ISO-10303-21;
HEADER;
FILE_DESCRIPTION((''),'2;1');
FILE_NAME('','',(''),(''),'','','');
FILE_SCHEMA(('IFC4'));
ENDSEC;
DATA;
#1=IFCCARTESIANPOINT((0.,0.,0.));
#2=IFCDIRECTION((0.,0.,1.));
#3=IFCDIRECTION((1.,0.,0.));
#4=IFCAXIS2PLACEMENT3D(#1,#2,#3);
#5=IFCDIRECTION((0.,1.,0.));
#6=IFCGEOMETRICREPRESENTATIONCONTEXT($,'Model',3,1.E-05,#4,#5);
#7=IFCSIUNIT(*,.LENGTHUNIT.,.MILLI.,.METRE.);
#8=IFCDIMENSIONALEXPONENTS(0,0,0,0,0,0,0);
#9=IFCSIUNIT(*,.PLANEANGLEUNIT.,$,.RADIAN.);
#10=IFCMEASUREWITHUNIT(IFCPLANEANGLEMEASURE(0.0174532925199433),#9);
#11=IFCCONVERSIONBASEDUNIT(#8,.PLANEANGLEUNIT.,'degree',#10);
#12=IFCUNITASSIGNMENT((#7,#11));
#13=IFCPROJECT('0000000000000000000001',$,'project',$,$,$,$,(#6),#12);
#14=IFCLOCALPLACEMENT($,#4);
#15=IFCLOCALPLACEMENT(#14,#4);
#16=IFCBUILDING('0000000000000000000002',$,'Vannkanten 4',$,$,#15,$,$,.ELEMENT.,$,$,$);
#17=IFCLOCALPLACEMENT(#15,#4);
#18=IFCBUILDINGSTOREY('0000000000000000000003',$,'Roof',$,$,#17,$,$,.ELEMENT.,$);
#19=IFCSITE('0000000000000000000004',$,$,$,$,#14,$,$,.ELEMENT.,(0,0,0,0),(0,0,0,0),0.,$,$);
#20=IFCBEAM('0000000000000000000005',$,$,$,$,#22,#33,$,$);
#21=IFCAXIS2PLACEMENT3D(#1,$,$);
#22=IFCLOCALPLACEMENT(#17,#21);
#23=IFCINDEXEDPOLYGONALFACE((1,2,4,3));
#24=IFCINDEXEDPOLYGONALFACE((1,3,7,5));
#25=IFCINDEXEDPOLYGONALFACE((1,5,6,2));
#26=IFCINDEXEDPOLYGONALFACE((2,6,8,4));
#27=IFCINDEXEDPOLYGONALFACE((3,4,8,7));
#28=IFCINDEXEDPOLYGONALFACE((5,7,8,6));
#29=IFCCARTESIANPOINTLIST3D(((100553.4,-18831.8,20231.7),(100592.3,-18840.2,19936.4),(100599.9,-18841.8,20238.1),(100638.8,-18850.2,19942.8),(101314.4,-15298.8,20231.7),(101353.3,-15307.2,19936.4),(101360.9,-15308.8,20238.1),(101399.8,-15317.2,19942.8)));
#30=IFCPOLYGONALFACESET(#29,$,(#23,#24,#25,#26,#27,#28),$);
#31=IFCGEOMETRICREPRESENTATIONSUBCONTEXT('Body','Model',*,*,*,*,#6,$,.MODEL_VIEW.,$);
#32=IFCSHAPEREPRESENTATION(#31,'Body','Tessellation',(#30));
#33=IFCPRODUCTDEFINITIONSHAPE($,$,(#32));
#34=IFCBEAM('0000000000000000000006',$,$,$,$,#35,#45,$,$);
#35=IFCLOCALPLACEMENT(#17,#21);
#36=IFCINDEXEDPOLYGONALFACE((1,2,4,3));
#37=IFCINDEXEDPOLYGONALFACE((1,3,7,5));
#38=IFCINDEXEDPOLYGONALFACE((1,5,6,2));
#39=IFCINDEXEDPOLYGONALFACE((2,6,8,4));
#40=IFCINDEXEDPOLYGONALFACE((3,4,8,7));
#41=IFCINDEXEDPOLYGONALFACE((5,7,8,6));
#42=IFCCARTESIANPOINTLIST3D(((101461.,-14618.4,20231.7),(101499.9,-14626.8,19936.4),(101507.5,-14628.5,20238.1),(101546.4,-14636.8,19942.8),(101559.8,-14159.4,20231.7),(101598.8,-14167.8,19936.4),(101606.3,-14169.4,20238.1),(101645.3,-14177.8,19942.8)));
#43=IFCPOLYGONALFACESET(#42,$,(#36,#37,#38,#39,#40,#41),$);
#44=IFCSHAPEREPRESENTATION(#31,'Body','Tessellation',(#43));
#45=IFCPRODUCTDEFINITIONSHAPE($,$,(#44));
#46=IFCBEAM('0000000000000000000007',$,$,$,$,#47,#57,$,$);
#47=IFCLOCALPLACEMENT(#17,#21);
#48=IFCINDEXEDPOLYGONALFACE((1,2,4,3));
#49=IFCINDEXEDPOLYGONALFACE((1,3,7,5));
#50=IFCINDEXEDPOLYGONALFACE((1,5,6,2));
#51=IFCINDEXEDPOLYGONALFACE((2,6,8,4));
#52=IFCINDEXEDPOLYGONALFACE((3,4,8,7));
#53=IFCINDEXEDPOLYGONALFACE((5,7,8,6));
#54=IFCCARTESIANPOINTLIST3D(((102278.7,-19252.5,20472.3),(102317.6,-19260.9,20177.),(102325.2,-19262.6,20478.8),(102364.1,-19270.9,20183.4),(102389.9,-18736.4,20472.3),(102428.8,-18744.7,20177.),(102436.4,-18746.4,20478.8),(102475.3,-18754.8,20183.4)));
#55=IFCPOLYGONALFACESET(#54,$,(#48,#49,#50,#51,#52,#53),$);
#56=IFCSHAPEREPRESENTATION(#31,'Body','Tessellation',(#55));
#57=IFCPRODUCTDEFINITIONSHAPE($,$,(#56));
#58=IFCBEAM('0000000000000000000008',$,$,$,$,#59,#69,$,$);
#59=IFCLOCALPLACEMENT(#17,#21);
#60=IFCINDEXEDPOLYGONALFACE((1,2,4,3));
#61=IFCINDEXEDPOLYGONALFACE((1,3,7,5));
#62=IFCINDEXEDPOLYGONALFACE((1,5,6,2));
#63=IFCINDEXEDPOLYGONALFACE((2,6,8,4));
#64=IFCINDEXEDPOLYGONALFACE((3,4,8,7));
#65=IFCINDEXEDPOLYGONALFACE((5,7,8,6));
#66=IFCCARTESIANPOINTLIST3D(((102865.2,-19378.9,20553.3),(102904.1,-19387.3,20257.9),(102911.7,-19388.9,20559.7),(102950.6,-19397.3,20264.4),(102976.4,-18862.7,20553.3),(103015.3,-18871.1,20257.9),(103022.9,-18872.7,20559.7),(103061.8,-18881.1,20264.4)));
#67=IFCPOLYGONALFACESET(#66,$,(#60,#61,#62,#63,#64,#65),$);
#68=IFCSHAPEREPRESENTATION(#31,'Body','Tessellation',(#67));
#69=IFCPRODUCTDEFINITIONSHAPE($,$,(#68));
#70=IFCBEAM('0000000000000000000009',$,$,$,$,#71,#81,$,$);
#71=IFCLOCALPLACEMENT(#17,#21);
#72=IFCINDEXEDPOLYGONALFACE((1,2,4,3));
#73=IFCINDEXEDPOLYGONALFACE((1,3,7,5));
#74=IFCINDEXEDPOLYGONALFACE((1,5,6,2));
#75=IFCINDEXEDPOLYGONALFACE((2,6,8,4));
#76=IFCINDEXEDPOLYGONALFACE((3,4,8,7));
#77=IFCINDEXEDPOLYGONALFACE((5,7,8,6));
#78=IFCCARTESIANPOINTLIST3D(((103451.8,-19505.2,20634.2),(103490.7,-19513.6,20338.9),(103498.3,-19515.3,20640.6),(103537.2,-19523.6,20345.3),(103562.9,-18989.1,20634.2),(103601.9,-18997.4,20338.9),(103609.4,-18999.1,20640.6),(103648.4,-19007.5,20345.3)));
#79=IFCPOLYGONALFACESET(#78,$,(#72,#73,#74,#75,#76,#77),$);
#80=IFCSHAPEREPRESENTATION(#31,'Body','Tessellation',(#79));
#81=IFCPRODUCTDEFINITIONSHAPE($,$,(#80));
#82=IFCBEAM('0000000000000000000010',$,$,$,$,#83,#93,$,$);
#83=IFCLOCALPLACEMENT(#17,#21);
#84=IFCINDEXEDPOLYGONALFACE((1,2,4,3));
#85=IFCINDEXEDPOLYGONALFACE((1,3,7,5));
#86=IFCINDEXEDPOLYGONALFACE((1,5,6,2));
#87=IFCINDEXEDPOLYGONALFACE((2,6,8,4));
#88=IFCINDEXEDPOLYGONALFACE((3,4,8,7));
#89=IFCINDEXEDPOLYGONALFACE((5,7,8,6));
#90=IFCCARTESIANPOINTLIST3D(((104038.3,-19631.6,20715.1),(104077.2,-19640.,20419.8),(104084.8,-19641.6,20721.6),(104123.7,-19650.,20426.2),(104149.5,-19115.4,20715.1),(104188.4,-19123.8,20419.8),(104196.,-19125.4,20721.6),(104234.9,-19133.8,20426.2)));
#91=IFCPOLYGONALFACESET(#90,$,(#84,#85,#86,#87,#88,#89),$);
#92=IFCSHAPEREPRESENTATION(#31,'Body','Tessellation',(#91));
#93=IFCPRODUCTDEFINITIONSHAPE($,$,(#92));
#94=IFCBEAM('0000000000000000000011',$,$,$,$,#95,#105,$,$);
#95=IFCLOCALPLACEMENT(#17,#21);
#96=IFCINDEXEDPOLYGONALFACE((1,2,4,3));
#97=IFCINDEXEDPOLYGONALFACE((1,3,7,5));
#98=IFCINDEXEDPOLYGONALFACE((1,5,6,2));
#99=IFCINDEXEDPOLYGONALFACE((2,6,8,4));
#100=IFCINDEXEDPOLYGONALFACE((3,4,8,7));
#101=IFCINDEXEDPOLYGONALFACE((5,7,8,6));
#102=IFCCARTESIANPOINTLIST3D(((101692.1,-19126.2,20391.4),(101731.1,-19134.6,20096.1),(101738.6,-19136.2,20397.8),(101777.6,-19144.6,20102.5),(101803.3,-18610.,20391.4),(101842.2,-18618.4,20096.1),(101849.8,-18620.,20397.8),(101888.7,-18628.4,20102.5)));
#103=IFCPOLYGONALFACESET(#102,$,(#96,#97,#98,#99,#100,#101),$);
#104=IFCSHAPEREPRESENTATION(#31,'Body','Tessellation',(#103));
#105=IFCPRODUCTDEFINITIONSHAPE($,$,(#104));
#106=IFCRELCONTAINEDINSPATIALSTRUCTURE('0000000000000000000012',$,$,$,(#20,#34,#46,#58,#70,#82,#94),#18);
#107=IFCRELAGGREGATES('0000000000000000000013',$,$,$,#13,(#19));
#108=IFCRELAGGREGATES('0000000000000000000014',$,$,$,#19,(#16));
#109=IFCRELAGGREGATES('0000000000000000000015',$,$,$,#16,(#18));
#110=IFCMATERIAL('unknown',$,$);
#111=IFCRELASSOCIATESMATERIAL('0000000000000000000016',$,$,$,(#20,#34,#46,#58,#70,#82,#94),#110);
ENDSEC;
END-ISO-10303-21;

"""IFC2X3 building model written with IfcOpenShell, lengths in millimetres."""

from ifc_helpers import new_model, entity, si_unit, converted_unit, direction, frame, origin_with_axes, place, context, subcontext, project, spatial, polyline, segment, composite_curve, outline, extrude, material, element, save


model = new_model("IFC2X3")

# Units and contexts
model_context = context("Model", 3, precision=1e-05, world=origin_with_axes(), true_north=direction((0.0, 1.0, 0.0)))
body_context = subcontext(model_context, "Body", "Model", "MODEL_VIEW")
ifc_project = project(units=[si_unit("LENGTHUNIT", "METRE", prefix="MILLI"), converted_unit("PLANEANGLEUNIT", "degree", entity("IfcPlaneAngleMeasure", 0.0174532925199433), si_unit("PLANEANGLEUNIT", "RADIAN"), dimensions=[0, 0, 0, 0, 0, 0, 0])], contexts=[model_context])

# Site, building, storey
site_placement = place(None, origin_with_axes())
site = spatial("IfcSite", under=ifc_project, at=site_placement, CompositionType="ELEMENT", RefLatitude=(0, 0, 0, 0), RefLongitude=(0, 0, 0, 0), RefElevation=0.0)
building_placement = place(site_placement, origin_with_axes())
building = spatial("IfcBuilding", under=site, at=building_placement, Name="Vannkanten 4", CompositionType="ELEMENT")
storey_placement = place(building_placement, origin_with_axes())
storey = spatial("IfcBuildingStorey", under=building, at=storey_placement, Name="Roof", CompositionType="ELEMENT")

# Shared definitions
ifc_material = material(Name="unknown")

# Beams
beam_1_placement = place(storey_placement, frame((100596.1, -18841.0, 20087.3), z_axis=(0.210582, 0.977576, 0.0), x_axis=(-0.968803, 0.208692, -0.133675)))
element("IfcBeam", 1, at=beam_1_placement, inside=storey, material=ifc_material, context=body_context, shape_type="SweptSolid", body=[
    extrude(outline(composite_curve([segment(polyline([(-24.0, -149.0), (-24.0, 149.0), (24.0, 149.0), (24.0, -149.0), (-24.0, -149.0)]), True, "CONTINUOUS")], self_intersect=False)), frame((0.0, 0.0, 0.0), z_axis=(0.0, 0.0, 1.0), x_axis=(1.0, 0.0, 0.0)), (0.0, 0.0, 1.0), 3614.0),
])
beam_2_placement = place(storey_placement, frame((101503.7, -14627.6, 20087.3), z_axis=(0.210582, 0.977576, 0.0), x_axis=(-0.968803, 0.208692, -0.133675)))
element("IfcBeam", 2, at=beam_2_placement, inside=storey, material=ifc_material, context=body_context, shape_type="SweptSolid", body=[
    extrude(outline(composite_curve([segment(polyline([(-24.0, -149.0), (-24.0, 149.0), (24.0, 149.0), (24.0, -149.0), (-24.0, -149.0)]), True, "CONTINUOUS")], self_intersect=False)), frame((0.0, 0.0, 0.0), z_axis=(0.0, 0.0, 1.0), x_axis=(1.0, 0.0, 0.0)), (0.0, 0.0, 1.0), 469.5),
])
beam_3_placement = place(storey_placement, frame((102321.4, -19261.7, 20327.9), z_axis=(0.210582, 0.977576, 0.0), x_axis=(-0.968803, 0.208692, -0.133675)))
element("IfcBeam", 3, at=beam_3_placement, inside=storey, material=ifc_material, context=body_context, shape_type="SweptSolid", body=[
    extrude(outline(composite_curve([segment(polyline([(-24.0, -149.0), (-24.0, 149.0), (24.0, 149.0), (24.0, -149.0), (-24.0, -149.0)]), True, "CONTINUOUS")], self_intersect=False)), frame((0.0, 0.0, 0.0), z_axis=(0.0, 0.0, 1.0), x_axis=(1.0, 0.0, 0.0)), (0.0, 0.0, 1.0), 528.0),
])
beam_4_placement = place(storey_placement, frame((102907.9, -19388.1, 20408.8), z_axis=(0.210582, 0.977576, 0.0), x_axis=(-0.968803, 0.208692, -0.133675)))
element("IfcBeam", 4, at=beam_4_placement, inside=storey, material=ifc_material, context=body_context, shape_type="SweptSolid", body=[
    extrude(outline(composite_curve([segment(polyline([(-24.0, -149.0), (-24.0, 149.0), (24.0, 149.0), (24.0, -149.0), (-24.0, -149.0)]), True, "CONTINUOUS")], self_intersect=False)), frame((0.0, 0.0, 0.0), z_axis=(0.0, 0.0, 1.0), x_axis=(1.0, 0.0, 0.0)), (0.0, 0.0, 1.0), 528.0),
])
beam_5_placement = place(storey_placement, frame((103494.5, -19514.4, 20489.7), z_axis=(0.210582, 0.977576, 0.0), x_axis=(-0.968803, 0.208692, -0.133675)))
element("IfcBeam", 5, at=beam_5_placement, inside=storey, material=ifc_material, context=body_context, shape_type="SweptSolid", body=[
    extrude(outline(composite_curve([segment(polyline([(-24.0, -149.0), (-24.0, 149.0), (24.0, 149.0), (24.0, -149.0), (-24.0, -149.0)]), True, "CONTINUOUS")], self_intersect=False)), frame((0.0, 0.0, 0.0), z_axis=(0.0, 0.0, 1.0), x_axis=(1.0, 0.0, 0.0)), (0.0, 0.0, 1.0), 528.0),
])
beam_6_placement = place(storey_placement, frame((104081.0, -19640.8, 20570.7), z_axis=(0.210582, 0.977576, 0.0), x_axis=(-0.968803, 0.208692, -0.133675)))
element("IfcBeam", 6, at=beam_6_placement, inside=storey, material=ifc_material, context=body_context, shape_type="SweptSolid", body=[
    extrude(outline(composite_curve([segment(polyline([(-24.0, -149.0), (-24.0, 149.0), (24.0, 149.0), (24.0, -149.0), (-24.0, -149.0)]), True, "CONTINUOUS")], self_intersect=False)), frame((0.0, 0.0, 0.0), z_axis=(0.0, 0.0, 1.0), x_axis=(1.0, 0.0, 0.0)), (0.0, 0.0, 1.0), 528.0),
])
beam_7_placement = place(storey_placement, frame((101734.8, -19135.4, 20247.0), z_axis=(0.210582, 0.977576, 0.0), x_axis=(-0.968803, 0.208692, -0.133675)))
element("IfcBeam", 7, at=beam_7_placement, inside=storey, material=ifc_material, context=body_context, shape_type="SweptSolid", body=[
    extrude(outline(composite_curve([segment(polyline([(-24.0, -149.0), (-24.0, 149.0), (24.0, 149.0), (24.0, -149.0), (-24.0, -149.0)]), True, "CONTINUOUS")], self_intersect=False)), frame((0.0, 0.0, 0.0), z_axis=(0.0, 0.0, 1.0), x_axis=(1.0, 0.0, 0.0)), (0.0, 0.0, 1.0), 528.0),
])

save(model, "model.ifc")
